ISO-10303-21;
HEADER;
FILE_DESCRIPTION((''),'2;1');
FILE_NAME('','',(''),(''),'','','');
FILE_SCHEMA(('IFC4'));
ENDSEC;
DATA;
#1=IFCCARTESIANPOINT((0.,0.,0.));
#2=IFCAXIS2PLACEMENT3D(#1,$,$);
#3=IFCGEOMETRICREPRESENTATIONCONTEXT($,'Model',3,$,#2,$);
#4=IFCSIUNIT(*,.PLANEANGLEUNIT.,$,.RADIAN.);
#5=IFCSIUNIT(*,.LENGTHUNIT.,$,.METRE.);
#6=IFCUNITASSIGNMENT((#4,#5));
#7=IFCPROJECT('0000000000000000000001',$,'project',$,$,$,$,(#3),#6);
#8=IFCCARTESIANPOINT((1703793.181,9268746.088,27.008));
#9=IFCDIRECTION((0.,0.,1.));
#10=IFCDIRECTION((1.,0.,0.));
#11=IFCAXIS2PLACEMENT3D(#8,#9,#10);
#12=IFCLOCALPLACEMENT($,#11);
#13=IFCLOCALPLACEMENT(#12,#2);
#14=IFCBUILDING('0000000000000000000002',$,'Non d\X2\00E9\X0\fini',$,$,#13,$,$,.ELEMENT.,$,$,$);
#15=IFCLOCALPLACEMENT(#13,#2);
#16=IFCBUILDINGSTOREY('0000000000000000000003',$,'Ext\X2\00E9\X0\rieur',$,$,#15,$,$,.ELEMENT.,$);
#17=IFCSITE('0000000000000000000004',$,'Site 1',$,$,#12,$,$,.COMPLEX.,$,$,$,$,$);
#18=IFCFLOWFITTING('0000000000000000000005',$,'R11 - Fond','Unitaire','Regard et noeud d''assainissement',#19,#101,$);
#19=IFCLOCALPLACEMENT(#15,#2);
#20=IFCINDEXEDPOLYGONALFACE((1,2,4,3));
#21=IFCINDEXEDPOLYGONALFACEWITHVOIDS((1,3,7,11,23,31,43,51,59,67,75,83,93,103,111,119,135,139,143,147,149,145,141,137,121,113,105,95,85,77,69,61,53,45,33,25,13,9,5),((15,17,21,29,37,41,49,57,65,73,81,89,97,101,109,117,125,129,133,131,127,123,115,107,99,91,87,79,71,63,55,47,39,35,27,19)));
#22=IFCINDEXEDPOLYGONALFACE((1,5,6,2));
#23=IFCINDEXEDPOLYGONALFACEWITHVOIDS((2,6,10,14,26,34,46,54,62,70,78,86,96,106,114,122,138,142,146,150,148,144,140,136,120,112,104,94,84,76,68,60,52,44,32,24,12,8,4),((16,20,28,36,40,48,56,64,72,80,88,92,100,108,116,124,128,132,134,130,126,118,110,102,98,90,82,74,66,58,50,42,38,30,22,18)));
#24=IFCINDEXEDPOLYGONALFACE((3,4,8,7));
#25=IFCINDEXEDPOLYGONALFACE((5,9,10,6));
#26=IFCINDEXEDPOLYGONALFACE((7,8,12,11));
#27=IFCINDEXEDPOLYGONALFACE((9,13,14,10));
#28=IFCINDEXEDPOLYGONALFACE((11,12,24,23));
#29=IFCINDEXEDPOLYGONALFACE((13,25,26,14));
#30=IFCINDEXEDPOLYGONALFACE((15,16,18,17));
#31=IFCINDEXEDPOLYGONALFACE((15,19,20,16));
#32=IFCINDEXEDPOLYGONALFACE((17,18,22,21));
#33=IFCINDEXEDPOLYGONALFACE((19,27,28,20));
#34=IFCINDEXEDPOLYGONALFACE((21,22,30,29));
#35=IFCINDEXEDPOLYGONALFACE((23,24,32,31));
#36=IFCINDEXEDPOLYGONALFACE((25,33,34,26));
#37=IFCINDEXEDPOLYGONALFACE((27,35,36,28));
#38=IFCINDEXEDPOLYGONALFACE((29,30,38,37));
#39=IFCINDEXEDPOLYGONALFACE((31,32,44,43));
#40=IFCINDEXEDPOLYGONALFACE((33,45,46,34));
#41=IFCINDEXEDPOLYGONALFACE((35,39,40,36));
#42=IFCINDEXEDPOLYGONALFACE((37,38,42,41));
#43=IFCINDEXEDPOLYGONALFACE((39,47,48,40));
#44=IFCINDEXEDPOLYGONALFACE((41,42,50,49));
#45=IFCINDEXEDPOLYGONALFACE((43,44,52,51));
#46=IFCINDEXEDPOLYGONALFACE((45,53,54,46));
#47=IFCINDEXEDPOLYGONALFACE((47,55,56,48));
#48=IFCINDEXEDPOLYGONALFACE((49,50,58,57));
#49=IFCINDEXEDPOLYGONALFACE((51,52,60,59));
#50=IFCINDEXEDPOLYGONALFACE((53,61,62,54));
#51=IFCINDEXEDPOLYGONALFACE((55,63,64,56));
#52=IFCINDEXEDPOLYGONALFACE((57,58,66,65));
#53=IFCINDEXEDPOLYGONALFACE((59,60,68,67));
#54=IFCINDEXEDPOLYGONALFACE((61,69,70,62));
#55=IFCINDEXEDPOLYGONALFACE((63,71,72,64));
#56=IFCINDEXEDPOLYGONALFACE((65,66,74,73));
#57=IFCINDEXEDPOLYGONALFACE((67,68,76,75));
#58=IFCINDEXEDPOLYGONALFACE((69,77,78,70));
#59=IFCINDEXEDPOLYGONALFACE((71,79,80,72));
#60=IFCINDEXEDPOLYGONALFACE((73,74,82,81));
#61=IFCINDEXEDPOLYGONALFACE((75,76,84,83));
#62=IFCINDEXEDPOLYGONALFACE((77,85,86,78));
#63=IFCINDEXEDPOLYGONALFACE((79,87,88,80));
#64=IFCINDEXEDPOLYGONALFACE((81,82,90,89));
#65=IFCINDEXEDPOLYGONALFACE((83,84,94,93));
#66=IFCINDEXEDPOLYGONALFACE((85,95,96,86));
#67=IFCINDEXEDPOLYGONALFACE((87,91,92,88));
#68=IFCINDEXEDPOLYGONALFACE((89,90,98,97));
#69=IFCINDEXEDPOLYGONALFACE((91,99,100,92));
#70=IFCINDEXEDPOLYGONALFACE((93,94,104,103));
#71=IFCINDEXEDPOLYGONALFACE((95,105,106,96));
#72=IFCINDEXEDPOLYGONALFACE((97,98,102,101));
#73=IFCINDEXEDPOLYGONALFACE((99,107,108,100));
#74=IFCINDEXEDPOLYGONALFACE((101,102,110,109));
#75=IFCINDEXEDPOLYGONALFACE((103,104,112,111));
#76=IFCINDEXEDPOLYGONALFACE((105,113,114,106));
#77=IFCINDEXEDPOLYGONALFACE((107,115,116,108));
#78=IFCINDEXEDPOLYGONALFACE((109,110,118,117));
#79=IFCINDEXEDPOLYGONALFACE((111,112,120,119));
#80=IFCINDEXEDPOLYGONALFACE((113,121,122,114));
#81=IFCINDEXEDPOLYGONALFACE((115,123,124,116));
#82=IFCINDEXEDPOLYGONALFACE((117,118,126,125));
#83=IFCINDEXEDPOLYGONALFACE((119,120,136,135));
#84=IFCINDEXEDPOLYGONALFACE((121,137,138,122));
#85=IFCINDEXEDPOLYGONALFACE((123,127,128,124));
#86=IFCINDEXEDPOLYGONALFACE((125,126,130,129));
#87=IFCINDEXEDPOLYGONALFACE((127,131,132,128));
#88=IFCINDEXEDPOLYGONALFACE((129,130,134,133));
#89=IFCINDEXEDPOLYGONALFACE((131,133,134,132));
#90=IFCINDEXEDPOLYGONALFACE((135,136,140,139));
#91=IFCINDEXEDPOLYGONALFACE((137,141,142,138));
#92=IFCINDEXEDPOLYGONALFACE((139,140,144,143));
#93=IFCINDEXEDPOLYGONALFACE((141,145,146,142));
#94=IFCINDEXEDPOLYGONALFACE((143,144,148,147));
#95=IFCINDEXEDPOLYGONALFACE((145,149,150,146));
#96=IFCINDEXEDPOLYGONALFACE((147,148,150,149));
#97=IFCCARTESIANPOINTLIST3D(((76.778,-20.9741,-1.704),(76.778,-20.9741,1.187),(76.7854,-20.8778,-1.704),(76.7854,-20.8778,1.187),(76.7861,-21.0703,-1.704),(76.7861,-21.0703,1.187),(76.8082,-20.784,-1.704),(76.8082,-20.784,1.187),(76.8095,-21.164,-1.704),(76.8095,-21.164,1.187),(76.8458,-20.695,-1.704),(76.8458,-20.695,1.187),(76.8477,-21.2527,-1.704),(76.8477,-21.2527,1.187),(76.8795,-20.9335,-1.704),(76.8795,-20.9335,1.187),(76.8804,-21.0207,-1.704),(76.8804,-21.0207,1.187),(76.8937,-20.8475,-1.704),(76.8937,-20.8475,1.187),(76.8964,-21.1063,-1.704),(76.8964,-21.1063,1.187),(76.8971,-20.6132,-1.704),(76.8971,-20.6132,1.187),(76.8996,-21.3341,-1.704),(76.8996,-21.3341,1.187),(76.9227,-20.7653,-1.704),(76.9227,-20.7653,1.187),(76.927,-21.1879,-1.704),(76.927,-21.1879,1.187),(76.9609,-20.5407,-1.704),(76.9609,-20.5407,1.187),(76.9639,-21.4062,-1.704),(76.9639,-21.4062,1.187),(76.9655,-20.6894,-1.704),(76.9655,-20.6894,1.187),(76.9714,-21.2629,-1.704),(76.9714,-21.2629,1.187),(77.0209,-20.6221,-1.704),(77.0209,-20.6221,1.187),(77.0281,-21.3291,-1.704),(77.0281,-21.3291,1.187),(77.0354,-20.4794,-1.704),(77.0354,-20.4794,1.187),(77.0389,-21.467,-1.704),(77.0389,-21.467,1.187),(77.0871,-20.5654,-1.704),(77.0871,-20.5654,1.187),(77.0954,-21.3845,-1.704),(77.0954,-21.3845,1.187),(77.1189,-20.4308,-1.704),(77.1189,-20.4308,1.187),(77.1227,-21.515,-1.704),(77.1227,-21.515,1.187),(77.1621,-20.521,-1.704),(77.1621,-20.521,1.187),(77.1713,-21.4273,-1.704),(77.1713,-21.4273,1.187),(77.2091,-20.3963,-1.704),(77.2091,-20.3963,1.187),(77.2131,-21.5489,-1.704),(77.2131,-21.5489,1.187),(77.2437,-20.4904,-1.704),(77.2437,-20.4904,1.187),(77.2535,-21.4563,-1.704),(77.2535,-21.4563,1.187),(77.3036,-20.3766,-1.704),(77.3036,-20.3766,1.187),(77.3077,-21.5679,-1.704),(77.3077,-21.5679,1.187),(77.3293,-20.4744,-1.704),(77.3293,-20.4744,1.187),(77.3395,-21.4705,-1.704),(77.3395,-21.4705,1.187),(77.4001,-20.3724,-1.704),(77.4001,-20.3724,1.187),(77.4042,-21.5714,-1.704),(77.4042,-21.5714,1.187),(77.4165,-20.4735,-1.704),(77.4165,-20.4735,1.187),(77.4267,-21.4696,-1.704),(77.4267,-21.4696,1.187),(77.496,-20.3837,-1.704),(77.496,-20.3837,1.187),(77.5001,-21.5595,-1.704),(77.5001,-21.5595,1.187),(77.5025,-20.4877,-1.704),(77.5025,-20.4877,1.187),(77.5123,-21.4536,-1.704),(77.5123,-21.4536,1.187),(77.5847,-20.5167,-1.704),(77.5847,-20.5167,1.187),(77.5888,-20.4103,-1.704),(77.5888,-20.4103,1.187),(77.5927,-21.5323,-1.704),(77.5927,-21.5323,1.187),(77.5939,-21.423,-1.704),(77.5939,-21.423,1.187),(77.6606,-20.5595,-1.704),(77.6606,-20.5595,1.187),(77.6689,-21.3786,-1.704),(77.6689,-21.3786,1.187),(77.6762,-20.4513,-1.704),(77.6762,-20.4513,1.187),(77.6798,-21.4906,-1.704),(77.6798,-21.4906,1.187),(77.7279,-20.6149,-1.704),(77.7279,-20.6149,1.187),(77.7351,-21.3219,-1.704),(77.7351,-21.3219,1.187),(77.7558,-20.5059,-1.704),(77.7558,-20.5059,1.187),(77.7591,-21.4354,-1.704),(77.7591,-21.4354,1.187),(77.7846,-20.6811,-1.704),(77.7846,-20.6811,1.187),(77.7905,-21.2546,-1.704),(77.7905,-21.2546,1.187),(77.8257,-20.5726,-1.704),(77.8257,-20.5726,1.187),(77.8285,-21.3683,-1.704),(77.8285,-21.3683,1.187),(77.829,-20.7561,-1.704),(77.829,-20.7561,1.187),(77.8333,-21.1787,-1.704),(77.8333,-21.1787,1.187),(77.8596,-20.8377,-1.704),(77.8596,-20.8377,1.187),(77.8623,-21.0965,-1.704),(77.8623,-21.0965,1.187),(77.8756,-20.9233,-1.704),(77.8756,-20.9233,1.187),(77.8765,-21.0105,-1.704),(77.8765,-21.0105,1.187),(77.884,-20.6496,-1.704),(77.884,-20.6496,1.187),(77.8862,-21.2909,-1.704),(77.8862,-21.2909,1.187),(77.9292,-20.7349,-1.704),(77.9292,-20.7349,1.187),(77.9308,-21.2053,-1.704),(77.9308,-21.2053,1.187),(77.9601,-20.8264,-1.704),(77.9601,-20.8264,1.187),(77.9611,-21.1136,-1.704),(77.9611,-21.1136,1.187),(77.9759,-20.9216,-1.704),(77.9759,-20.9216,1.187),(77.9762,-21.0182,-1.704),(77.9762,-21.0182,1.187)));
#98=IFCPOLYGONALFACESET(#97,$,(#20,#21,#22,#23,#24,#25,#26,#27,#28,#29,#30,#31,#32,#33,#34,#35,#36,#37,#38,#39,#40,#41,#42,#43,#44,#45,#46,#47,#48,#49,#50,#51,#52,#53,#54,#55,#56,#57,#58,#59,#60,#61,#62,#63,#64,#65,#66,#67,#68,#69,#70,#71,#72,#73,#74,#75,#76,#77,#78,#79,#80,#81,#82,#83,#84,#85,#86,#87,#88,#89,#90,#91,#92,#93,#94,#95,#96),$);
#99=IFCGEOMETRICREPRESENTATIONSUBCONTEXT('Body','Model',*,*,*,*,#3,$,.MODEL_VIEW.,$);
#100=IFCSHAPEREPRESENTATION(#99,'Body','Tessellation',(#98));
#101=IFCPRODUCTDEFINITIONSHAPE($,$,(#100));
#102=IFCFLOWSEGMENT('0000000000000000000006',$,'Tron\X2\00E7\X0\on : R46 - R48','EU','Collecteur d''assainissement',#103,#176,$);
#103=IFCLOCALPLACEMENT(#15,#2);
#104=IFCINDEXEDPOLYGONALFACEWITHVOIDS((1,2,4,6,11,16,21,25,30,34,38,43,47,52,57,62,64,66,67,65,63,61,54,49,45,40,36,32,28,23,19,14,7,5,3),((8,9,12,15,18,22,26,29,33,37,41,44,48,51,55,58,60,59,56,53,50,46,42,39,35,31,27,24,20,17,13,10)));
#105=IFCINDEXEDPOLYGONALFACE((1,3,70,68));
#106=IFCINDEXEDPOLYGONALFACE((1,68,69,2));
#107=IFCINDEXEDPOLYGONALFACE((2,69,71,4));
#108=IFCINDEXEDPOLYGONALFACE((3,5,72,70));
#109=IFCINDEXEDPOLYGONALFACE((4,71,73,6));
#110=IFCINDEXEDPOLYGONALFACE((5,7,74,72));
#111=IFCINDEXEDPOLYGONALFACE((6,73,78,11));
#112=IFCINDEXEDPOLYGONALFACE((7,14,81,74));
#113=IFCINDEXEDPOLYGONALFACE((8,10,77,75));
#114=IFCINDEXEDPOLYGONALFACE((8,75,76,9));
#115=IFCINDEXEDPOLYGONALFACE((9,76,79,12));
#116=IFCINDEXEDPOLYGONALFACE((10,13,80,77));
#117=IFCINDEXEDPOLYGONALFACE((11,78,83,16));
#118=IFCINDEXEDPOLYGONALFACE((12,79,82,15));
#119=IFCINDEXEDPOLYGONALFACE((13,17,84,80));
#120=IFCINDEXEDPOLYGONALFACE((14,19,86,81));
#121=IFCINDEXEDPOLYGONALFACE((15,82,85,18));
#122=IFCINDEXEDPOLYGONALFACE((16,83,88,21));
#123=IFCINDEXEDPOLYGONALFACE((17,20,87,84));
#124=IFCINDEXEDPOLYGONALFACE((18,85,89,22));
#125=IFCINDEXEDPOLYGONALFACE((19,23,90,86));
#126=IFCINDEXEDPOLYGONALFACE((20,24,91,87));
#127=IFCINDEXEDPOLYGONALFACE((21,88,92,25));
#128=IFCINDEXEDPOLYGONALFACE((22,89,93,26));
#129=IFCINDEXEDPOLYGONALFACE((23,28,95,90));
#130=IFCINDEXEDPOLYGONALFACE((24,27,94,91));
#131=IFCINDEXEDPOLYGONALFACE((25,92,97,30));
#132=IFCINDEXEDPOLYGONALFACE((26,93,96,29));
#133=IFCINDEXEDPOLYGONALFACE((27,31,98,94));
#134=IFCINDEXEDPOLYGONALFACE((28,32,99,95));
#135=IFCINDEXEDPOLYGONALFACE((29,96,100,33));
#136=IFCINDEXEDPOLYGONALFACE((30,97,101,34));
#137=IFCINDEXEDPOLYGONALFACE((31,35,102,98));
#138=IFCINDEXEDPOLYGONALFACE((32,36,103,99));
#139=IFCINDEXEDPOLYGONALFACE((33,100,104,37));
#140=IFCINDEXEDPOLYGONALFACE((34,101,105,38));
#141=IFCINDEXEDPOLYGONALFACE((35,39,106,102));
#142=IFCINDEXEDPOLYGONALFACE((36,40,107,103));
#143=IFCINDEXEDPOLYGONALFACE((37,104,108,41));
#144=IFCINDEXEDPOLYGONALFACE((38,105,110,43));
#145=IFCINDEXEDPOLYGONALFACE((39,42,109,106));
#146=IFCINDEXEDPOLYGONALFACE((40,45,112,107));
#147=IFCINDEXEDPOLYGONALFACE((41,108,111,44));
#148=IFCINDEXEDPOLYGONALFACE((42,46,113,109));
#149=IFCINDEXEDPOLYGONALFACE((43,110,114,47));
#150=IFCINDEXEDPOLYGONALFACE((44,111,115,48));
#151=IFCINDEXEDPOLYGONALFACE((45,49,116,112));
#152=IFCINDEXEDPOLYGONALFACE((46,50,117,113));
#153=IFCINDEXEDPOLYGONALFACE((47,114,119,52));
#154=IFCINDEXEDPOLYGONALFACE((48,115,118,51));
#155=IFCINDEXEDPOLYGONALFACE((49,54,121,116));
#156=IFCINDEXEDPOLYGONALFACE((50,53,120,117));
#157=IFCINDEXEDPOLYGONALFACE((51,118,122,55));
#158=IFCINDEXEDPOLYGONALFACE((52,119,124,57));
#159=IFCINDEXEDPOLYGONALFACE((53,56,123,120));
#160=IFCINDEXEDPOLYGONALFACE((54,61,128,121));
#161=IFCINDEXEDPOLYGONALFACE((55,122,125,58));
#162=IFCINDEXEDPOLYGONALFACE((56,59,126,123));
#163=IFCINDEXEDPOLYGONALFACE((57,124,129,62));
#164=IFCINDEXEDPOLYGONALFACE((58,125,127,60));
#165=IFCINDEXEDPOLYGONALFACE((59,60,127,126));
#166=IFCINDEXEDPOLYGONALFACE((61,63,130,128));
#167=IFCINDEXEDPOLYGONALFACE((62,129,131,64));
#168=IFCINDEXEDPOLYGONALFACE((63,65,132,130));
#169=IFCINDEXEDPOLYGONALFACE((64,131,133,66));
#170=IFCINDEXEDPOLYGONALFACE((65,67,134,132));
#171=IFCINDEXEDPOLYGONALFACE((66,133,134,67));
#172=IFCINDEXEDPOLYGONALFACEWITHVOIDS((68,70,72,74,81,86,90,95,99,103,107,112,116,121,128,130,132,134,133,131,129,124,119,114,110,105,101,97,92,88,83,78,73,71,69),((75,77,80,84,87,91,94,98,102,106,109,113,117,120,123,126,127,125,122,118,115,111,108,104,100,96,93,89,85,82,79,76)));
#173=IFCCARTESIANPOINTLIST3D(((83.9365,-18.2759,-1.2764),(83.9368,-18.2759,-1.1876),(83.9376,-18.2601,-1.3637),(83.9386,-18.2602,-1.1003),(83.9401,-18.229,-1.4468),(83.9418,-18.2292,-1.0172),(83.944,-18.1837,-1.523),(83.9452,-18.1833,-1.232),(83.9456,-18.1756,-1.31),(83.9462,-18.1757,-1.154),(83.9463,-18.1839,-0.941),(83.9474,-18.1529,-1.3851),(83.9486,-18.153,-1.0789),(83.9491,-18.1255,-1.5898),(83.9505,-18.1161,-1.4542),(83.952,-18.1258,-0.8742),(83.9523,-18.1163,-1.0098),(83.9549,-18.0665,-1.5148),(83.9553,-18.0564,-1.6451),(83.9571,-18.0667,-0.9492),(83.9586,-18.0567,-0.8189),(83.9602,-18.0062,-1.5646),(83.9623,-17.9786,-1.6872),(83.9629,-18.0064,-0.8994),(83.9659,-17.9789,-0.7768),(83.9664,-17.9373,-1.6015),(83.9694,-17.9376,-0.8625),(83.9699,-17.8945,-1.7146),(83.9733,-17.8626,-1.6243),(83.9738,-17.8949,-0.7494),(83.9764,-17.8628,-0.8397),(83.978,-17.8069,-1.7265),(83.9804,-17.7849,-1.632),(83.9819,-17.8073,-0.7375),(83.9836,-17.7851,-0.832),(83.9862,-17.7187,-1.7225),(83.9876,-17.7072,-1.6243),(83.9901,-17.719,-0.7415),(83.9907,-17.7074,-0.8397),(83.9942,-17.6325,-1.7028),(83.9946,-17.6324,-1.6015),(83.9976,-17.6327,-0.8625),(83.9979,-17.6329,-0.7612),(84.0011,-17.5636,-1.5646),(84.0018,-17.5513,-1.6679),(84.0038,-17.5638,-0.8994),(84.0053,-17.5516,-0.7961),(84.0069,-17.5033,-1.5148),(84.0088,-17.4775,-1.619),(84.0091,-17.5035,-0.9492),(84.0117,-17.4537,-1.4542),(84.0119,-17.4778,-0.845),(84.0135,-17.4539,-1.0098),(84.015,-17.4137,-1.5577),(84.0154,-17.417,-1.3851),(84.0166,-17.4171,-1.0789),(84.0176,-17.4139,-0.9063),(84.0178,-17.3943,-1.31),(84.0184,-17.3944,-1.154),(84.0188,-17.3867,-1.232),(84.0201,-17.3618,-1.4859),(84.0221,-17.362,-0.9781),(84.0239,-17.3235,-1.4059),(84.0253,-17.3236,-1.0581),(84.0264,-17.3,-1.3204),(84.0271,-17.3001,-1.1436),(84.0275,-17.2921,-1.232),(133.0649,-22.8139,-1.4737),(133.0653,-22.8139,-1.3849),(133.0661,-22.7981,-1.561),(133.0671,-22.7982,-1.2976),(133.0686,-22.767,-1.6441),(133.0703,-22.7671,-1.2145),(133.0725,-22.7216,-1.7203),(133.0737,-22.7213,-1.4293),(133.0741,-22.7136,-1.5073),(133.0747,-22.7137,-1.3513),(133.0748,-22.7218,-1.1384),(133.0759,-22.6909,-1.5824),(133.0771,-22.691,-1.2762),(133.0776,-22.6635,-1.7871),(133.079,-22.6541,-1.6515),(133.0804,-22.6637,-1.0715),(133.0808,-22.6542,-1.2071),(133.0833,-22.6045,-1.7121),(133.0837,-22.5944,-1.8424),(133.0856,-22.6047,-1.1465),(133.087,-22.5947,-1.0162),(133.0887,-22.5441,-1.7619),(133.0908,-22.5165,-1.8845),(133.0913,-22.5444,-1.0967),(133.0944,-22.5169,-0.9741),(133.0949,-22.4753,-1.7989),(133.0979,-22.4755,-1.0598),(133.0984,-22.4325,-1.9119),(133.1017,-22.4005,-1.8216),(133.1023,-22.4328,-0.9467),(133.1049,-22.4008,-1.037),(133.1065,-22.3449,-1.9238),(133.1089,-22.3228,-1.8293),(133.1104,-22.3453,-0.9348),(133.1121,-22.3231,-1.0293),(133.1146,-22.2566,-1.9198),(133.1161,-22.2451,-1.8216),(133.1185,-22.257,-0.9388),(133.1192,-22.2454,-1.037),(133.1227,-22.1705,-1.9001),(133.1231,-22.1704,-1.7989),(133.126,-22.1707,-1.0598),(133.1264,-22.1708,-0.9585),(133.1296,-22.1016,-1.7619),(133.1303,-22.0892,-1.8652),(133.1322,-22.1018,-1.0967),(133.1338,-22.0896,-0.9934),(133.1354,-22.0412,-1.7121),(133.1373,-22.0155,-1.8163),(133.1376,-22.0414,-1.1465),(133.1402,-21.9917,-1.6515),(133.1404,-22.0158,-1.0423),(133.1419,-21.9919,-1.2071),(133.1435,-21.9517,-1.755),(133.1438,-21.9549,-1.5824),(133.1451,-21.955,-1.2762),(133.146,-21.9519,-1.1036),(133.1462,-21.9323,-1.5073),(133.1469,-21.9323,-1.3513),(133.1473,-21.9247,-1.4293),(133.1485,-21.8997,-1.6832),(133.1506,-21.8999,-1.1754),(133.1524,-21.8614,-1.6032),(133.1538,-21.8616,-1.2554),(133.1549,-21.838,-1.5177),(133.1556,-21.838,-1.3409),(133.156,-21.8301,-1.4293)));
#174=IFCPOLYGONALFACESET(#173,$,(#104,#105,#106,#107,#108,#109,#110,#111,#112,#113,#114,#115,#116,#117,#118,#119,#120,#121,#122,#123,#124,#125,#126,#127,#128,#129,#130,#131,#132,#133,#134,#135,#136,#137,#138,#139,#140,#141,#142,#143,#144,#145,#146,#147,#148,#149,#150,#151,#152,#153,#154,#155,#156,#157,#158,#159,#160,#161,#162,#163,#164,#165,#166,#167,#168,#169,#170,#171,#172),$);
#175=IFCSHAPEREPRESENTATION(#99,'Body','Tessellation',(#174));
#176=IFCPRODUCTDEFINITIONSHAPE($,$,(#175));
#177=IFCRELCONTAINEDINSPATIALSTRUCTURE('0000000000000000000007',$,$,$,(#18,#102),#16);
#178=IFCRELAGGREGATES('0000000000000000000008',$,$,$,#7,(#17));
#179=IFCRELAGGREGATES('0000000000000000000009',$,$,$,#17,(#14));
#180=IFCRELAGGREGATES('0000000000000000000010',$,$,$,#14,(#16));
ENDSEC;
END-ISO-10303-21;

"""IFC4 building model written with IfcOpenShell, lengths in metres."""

from ifc_helpers import new_model, si_unit, frame, origin, origin_2d, place, context, subcontext, project, spatial, hollow_circle, extrude, element, save


model = new_model("IFC4")

# Units and contexts
model_context = context("Model", 3, world=origin())
body_context = subcontext(model_context, "Body", "Model", "MODEL_VIEW")
ifc_project = project(units=[si_unit("PLANEANGLEUNIT", "RADIAN"), si_unit("LENGTHUNIT", "METRE")], contexts=[model_context])

# Site, building, storey
site_placement = place(None, frame((1703793.181, 9268746.088, 27.008), z_axis=(0.0, 0.0, 1.0), x_axis=(1.0, 0.0, 0.0)))
site = spatial("IfcSite", under=ifc_project, at=site_placement, Name="Site 1", CompositionType="COMPLEX")
building_placement = place(site_placement, origin())
building = spatial("IfcBuilding", under=site, at=building_placement, Name="Non défini", CompositionType="ELEMENT")
storey_placement = place(building_placement, origin())
storey = spatial("IfcBuildingStorey", under=building, at=storey_placement, Name="Extérieur", CompositionType="ELEMENT")

# Flow fitting
flow_fitting_1_placement = place(storey_placement, origin())
element("IfcFlowFitting", 1, at=flow_fitting_1_placement, inside=storey, Name="R11 - Fond", Description="Unitaire", ObjectType="Regard et noeud d'assainissement", context=body_context, shape_type="SweptSolid", body=[
    extrude(hollow_circle(Radius=0.6, WallThickness=0.1, at=origin_2d()), frame((77.378, -20.972, -1.704), z_axis=(0.0, 0.0, 1.0), x_axis=(0.997, -0.077, 0.0)), (0.0, 0.0, 1.0), 2.891),
])

# Flow segment
flow_segment_1_placement = place(storey_placement, origin())
element("IfcFlowSegment", 2, at=flow_segment_1_placement, inside=storey, Name="Tronçon : R46 - R48", Description="EU", ObjectType="Collecteur d'assainissement", context=body_context, shape_type="SweptSolid", body=[
    extrude(hollow_circle(Radius=0.495, WallThickness=0.095, at=origin_2d()), frame((83.982, -17.785, -1.232), z_axis=(0.996, -0.092, -0.004), x_axis=(0.092, 0.996, 0.0)), (0.0, 0.0, 1.0), 49.338),
])

save(model, "model.ifc")
